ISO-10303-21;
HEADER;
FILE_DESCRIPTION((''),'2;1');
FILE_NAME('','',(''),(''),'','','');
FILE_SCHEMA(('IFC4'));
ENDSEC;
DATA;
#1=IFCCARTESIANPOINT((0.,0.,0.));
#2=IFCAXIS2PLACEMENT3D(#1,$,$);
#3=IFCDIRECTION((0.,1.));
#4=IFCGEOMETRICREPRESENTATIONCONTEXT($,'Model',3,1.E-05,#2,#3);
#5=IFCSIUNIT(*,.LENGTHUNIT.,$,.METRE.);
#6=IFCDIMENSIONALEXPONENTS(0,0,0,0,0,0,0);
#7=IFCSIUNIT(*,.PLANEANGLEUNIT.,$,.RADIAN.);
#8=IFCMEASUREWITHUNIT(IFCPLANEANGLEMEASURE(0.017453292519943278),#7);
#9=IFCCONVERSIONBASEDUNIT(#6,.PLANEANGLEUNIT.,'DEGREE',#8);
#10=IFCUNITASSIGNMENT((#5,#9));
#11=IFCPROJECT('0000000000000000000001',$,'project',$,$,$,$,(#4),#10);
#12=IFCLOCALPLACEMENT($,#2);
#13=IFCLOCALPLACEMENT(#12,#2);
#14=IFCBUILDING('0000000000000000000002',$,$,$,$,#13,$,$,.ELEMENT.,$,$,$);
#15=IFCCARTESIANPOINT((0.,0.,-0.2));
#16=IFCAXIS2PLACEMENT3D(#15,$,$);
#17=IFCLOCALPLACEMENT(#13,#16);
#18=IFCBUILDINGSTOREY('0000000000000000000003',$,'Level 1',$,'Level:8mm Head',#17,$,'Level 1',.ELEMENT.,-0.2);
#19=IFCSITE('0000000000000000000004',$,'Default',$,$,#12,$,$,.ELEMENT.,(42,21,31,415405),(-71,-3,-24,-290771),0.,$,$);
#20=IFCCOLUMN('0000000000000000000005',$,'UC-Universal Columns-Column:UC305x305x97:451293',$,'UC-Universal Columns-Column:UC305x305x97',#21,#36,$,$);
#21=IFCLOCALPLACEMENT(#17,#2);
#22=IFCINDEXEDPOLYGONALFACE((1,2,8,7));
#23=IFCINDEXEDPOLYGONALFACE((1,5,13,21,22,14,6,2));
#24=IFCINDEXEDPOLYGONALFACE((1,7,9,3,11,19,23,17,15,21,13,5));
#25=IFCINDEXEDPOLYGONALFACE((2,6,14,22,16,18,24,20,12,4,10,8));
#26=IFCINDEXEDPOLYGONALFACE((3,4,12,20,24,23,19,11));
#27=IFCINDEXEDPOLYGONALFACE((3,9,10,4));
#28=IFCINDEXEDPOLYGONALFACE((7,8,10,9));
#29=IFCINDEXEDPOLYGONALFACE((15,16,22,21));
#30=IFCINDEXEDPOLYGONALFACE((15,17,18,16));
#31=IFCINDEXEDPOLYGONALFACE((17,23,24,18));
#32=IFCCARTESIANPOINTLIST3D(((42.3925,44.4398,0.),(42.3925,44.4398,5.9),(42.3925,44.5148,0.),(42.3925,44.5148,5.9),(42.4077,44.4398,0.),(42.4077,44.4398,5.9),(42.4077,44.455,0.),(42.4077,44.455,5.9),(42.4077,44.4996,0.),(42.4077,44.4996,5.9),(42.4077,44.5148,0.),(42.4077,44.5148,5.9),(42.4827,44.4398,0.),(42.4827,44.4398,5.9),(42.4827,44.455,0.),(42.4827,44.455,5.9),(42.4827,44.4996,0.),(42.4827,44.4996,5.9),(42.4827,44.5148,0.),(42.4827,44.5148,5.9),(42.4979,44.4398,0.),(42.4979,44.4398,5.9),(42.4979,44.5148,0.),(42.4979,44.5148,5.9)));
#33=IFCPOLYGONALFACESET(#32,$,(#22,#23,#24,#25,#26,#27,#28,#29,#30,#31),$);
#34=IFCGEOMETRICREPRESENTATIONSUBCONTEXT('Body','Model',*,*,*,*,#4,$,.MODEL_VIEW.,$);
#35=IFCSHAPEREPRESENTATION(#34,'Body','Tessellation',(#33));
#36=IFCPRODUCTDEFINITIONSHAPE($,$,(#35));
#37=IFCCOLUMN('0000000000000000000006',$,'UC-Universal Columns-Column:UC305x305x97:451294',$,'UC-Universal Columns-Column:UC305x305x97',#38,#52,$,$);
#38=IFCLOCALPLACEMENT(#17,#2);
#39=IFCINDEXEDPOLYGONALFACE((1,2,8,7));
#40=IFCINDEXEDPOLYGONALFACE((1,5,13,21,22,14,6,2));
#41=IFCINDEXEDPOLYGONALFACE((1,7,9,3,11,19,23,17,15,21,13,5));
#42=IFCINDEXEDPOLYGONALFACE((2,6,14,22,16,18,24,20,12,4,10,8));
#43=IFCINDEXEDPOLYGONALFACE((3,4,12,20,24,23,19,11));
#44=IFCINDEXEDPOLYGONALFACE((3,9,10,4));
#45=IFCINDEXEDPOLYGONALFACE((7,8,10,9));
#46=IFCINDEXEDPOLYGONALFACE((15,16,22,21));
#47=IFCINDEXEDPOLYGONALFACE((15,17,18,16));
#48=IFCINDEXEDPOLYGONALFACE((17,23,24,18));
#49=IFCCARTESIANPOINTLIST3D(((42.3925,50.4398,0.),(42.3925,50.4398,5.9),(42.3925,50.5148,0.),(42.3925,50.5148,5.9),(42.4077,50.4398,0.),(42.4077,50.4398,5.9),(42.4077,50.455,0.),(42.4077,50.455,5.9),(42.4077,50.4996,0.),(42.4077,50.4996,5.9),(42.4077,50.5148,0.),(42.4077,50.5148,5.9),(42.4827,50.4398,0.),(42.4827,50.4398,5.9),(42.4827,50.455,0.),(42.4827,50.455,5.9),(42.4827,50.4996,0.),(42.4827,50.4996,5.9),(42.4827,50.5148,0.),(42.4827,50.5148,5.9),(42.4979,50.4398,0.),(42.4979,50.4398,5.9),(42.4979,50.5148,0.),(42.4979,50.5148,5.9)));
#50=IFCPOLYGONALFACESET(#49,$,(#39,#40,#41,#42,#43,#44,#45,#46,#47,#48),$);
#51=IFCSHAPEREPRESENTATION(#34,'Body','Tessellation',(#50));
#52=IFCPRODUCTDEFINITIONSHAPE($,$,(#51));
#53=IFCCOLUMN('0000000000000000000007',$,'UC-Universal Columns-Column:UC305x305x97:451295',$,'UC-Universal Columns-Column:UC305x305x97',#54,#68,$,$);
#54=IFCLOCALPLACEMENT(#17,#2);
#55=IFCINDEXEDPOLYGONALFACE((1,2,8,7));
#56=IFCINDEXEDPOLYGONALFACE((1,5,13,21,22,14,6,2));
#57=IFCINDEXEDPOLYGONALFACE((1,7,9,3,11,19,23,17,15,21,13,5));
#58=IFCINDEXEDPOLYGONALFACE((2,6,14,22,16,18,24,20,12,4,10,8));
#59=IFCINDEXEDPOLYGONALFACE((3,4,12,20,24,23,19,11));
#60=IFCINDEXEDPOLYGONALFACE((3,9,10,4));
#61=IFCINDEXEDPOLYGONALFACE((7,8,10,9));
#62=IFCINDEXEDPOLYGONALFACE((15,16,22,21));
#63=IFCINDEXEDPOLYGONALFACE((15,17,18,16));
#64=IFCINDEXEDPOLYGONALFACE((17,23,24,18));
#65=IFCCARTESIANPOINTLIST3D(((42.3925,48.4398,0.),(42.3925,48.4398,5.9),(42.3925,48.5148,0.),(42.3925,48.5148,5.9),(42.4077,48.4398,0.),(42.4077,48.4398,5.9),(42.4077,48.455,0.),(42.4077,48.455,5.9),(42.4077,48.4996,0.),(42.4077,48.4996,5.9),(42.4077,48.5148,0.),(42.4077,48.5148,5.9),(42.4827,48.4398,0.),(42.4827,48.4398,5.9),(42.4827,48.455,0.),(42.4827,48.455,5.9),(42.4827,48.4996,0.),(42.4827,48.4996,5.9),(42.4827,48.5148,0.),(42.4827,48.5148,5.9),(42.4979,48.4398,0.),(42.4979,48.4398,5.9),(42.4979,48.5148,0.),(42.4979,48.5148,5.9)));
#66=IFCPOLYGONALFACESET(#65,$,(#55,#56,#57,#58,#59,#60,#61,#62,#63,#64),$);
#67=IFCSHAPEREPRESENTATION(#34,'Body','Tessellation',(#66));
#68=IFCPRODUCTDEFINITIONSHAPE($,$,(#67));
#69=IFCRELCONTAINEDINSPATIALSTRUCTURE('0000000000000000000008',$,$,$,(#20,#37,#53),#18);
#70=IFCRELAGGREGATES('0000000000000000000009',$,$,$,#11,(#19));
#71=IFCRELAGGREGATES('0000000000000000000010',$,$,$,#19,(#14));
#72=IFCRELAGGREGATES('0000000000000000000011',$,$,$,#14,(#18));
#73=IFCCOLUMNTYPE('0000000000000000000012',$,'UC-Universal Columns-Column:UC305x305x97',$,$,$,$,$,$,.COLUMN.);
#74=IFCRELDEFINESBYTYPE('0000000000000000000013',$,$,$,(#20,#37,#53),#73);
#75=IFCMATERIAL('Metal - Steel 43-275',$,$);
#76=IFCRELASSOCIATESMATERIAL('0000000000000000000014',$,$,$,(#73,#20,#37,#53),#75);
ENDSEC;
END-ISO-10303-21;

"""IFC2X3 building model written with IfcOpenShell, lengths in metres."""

from ifc_helpers import new_model, entity, si_unit, converted_unit, direction, frame, frame_2d, origin, place, context, subcontext, project, spatial, polyline, circle_curve, parameter, trimmed, segment, composite_curve, outline, extrude, source, transform, mapped, material, type_object, type_shapes, element, save


model = new_model("IFC2X3")

# Units and contexts
model_context = context("Model", 3, precision=1e-05, world=origin(), true_north=direction((0.0, 1.0)))
body_context = subcontext(model_context, "Body", "Model", "MODEL_VIEW")
ifc_project = project(units=[si_unit("LENGTHUNIT", "METRE"), converted_unit("PLANEANGLEUNIT", "DEGREE", entity("IfcPlaneAngleMeasure", 0.017453292519943278), si_unit("PLANEANGLEUNIT", "RADIAN"), dimensions=[0, 0, 0, 0, 0, 0, 0])], contexts=[model_context])

# Site, building, storey
site_placement = place(None, origin())
site = spatial("IfcSite", under=ifc_project, at=site_placement, Name="Default", CompositionType="ELEMENT", RefLatitude=(42, 21, 31, 415405), RefLongitude=(-71, -3, -24, -290771), RefElevation=0.0)
building_placement = place(site_placement, origin())
building = spatial("IfcBuilding", under=site, at=building_placement, CompositionType="ELEMENT")
storey_placement = place(building_placement, frame((0.0, 0.0, -0.2)))
storey = spatial("IfcBuildingStorey", under=building, at=storey_placement, Name="Level 1", ObjectType="Level:8mm Head", LongName="Level 1", CompositionType="ELEMENT", Elevation=-0.2)

# Columns
ifc_material = material(Name="Metal - Steel 43-275")
column_type = type_object("IfcColumnType", Name="UC-Universal Columns-Column:UC305x305x97", PredefinedType="COLUMN", material=ifc_material)
shared_shape = source(origin(), body_context, "Body", "SweptSolid", [
    extrude(outline(composite_curve([segment(polyline([(-0.0375, -0.0375), (0.0375, -0.0375)]), True, "CONTINUOUS"), segment(polyline([(0.0375, -0.0375), (0.0527, -0.0375)]), True, "CONTINUOUS"), segment(trimmed(circle_curve(frame_2d((0.0527, -0.0223), x_axis=(-1.0, 0.0)), 0.0152), [parameter(0.0)], [parameter(90.0)], True, "PARAMETER"), False, "CONTINUOUS"), segment(polyline([(0.0375, -0.0223), (0.0375, 0.0223)]), True, "CONTINUOUS"), segment(trimmed(circle_curve(frame_2d((0.0527, 0.0223), x_axis=(-1.0, 0.0)), 0.0152), [parameter(270.0)], [parameter(0.0)], True, "PARAMETER"), False, "CONTINUOUS"), segment(polyline([(0.0527, 0.0375), (0.0375, 0.0375)]), True, "CONTINUOUS"), segment(polyline([(0.0375, 0.0375), (-0.0375, 0.0375)]), True, "CONTINUOUS"), segment(polyline([(-0.0375, 0.0375), (-0.0527, 0.0375)]), True, "CONTINUOUS"), segment(trimmed(circle_curve(frame_2d((-0.0527, 0.0223), x_axis=(-1.0, 0.0)), 0.0152), [parameter(180.0)], [parameter(270.0)], True, "PARAMETER"), False, "CONTINUOUS"), segment(polyline([(-0.0375, 0.0223), (-0.0375, -0.0223)]), True, "CONTINUOUS"), segment(trimmed(circle_curve(frame_2d((-0.0527, -0.0223), x_axis=(-1.0, 0.0)), 0.0152), [parameter(90.0)], [parameter(180.0)], True, "PARAMETER"), False, "CONTINUOUS"), segment(polyline([(-0.0527, -0.0375), (-0.0375, -0.0375)]), True, "CONTINUOUS")], self_intersect=False)), frame((0.0, 0.0, -0.2), z_axis=(0.0, 0.0, 1.0), x_axis=(-1.0, 0.0, 0.0)), (0.0, 0.0, 1.0), 5.9),
])
type_shapes(column_type, [shared_shape])
for number, where, z_axis, x_axis, name in (
    (1, (42.4452, 44.4773, 0.2), (0.0, 0.0, 1.0), (-1.0, 0.0, 0.0), "UC-Universal Columns-Column:UC305x305x97:451293"),
    (2, (42.4452, 50.4773, 0.2), (0.0, 0.0, 1.0), (-1.0, 0.0, 0.0), "UC-Universal Columns-Column:UC305x305x97:451294"),
    (3, (42.4452, 48.4773, 0.2), (0.0, 0.0, 1.0), (-1.0, 0.0, 0.0), "UC-Universal Columns-Column:UC305x305x97:451295"),
):
    element("IfcColumn", number, at=place(storey_placement, frame(where, z_axis=z_axis, x_axis=x_axis)), inside=storey, type_object=column_type, material=ifc_material, Name=name, ObjectType="UC-Universal Columns-Column:UC305x305x97", context=body_context, shape_type="MappedRepresentation", body=[
        mapped(shared_shape, transform((0.0, 0.0, 0.0), scale=1.0)),
    ])

save(model, "model.ifc")
